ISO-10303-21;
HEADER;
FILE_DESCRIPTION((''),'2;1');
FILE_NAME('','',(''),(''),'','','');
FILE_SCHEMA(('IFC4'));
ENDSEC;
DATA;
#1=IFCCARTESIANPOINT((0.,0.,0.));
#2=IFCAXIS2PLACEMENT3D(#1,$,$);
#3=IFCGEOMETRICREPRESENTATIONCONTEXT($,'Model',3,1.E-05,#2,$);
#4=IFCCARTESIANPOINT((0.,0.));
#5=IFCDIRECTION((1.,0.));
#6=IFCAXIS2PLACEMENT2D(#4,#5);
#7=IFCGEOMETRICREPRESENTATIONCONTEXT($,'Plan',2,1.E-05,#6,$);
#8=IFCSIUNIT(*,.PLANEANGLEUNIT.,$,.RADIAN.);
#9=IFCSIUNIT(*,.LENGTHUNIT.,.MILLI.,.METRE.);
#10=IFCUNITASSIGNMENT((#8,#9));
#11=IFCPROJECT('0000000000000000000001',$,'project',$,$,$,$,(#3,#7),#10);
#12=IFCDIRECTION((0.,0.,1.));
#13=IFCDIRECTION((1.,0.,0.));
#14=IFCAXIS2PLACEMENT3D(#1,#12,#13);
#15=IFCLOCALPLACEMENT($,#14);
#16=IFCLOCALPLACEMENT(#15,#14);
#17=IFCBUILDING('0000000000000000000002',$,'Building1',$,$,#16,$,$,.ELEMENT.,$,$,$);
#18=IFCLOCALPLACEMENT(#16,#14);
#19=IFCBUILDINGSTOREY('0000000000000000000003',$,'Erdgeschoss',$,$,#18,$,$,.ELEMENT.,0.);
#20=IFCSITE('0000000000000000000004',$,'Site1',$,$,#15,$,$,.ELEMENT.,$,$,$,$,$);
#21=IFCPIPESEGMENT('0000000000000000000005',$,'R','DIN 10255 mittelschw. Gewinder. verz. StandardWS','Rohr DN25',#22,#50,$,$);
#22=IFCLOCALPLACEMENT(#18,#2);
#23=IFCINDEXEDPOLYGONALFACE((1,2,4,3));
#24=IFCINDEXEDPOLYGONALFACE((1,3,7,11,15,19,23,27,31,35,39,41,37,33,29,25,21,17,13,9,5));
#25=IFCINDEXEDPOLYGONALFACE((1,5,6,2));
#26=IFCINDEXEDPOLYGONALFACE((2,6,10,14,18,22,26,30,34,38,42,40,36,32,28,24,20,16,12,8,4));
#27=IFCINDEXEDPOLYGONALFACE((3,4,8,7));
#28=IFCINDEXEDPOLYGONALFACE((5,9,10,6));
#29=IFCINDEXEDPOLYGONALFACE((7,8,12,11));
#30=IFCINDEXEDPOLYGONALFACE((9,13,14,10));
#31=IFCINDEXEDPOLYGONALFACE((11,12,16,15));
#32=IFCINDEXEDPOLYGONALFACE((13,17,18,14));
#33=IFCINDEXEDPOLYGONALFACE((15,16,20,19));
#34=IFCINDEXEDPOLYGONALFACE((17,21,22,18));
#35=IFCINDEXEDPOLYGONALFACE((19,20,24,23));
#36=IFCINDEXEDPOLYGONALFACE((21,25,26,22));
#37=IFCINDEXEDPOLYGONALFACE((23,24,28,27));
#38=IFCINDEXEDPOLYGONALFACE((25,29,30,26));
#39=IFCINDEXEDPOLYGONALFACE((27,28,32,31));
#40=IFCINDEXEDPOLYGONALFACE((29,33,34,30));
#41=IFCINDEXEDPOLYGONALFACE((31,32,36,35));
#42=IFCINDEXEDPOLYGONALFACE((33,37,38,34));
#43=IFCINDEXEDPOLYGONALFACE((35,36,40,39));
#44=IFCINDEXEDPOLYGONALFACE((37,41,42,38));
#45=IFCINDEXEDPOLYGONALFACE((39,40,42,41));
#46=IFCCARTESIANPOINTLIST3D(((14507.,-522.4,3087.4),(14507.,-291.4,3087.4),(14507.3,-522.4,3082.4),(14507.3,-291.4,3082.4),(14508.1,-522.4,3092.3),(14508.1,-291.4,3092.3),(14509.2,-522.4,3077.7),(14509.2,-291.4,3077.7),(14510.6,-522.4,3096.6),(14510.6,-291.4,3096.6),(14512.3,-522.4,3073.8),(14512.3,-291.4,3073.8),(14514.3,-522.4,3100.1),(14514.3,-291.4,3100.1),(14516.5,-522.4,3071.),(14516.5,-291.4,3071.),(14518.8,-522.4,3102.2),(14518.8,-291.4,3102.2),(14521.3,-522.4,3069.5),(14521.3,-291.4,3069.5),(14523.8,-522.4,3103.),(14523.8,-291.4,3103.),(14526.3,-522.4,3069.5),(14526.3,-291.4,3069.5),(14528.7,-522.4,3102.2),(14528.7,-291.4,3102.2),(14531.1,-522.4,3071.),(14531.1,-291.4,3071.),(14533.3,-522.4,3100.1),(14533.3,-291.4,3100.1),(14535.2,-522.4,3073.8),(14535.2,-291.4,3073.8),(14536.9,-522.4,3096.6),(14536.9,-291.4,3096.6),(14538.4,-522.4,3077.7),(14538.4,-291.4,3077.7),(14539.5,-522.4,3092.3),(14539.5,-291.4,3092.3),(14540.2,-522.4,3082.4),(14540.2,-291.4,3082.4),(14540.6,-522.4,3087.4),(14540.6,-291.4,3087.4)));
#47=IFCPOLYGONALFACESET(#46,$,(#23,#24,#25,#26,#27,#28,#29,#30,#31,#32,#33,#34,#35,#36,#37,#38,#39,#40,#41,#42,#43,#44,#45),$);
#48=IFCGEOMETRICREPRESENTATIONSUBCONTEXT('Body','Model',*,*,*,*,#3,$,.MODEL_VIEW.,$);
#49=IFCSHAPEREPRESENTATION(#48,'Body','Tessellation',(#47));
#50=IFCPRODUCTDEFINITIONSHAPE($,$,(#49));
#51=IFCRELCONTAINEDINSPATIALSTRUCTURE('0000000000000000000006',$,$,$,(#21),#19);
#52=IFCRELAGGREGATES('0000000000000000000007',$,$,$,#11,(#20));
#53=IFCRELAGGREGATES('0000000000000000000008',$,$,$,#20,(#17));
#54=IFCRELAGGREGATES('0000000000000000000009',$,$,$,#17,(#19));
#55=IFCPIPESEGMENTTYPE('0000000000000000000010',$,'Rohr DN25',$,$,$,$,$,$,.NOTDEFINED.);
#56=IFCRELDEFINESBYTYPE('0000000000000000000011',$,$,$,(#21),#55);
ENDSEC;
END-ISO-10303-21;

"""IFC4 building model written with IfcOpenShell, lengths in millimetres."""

from ifc_helpers import new_model, si_unit, frame, origin, origin_with_axes, origin_2d_with_axis, place, context, subcontext, project, spatial, circle, extrude, type_object, element, save


model = new_model("IFC4")

# Units and contexts
model_context = context("Model", 3, precision=1e-05, world=origin())
plan_context = context("Plan", 2, precision=1e-05, world=origin_2d_with_axis())
body_context = subcontext(model_context, "Body", "Model", "MODEL_VIEW")
ifc_project = project(units=[si_unit("PLANEANGLEUNIT", "RADIAN"), si_unit("LENGTHUNIT", "METRE", prefix="MILLI")], contexts=[model_context, plan_context])

# Site, building, storey
site_placement = place(None, origin_with_axes())
site = spatial("IfcSite", under=ifc_project, at=site_placement, Name="Site1", CompositionType="ELEMENT")
building_placement = place(site_placement, origin_with_axes())
building = spatial("IfcBuilding", under=site, at=building_placement, Name="Building1", CompositionType="ELEMENT")
storey_placement = place(building_placement, origin_with_axes())
storey = spatial("IfcBuildingStorey", under=building, at=storey_placement, Name="Erdgeschoss", CompositionType="ELEMENT", Elevation=0.0)

# Pipe segment
pipe_segment_type_1 = type_object("IfcPipeSegmentType", Name="Rohr DN25", PredefinedType="NOTDEFINED")
pipe_segment_1_placement = place(storey_placement, frame((14523.6, -406.9, 3086.1), z_axis=(0.0, 0.0, 1.0), x_axis=(1.0, 0.0, 0.0)))
element("IfcPipeSegment", 1, at=pipe_segment_1_placement, inside=storey, type_object=pipe_segment_type_1, Name="R", Description="DIN 10255 mittelschw. Gewinder. verz. StandardWS", ObjectType="Rohr DN25", context=body_context, shape_type="SolidModel", body=[
    extrude(circle(Radius=16.9, at=origin_2d_with_axis()), frame((0.1, -115.5, 0.0), z_axis=(0.000001, 1.0, 0.0), x_axis=(0.0, 0.0, 1.0)), (0.0, 0.0, 1.0), 231.0),
])

save(model, "model.ifc")
